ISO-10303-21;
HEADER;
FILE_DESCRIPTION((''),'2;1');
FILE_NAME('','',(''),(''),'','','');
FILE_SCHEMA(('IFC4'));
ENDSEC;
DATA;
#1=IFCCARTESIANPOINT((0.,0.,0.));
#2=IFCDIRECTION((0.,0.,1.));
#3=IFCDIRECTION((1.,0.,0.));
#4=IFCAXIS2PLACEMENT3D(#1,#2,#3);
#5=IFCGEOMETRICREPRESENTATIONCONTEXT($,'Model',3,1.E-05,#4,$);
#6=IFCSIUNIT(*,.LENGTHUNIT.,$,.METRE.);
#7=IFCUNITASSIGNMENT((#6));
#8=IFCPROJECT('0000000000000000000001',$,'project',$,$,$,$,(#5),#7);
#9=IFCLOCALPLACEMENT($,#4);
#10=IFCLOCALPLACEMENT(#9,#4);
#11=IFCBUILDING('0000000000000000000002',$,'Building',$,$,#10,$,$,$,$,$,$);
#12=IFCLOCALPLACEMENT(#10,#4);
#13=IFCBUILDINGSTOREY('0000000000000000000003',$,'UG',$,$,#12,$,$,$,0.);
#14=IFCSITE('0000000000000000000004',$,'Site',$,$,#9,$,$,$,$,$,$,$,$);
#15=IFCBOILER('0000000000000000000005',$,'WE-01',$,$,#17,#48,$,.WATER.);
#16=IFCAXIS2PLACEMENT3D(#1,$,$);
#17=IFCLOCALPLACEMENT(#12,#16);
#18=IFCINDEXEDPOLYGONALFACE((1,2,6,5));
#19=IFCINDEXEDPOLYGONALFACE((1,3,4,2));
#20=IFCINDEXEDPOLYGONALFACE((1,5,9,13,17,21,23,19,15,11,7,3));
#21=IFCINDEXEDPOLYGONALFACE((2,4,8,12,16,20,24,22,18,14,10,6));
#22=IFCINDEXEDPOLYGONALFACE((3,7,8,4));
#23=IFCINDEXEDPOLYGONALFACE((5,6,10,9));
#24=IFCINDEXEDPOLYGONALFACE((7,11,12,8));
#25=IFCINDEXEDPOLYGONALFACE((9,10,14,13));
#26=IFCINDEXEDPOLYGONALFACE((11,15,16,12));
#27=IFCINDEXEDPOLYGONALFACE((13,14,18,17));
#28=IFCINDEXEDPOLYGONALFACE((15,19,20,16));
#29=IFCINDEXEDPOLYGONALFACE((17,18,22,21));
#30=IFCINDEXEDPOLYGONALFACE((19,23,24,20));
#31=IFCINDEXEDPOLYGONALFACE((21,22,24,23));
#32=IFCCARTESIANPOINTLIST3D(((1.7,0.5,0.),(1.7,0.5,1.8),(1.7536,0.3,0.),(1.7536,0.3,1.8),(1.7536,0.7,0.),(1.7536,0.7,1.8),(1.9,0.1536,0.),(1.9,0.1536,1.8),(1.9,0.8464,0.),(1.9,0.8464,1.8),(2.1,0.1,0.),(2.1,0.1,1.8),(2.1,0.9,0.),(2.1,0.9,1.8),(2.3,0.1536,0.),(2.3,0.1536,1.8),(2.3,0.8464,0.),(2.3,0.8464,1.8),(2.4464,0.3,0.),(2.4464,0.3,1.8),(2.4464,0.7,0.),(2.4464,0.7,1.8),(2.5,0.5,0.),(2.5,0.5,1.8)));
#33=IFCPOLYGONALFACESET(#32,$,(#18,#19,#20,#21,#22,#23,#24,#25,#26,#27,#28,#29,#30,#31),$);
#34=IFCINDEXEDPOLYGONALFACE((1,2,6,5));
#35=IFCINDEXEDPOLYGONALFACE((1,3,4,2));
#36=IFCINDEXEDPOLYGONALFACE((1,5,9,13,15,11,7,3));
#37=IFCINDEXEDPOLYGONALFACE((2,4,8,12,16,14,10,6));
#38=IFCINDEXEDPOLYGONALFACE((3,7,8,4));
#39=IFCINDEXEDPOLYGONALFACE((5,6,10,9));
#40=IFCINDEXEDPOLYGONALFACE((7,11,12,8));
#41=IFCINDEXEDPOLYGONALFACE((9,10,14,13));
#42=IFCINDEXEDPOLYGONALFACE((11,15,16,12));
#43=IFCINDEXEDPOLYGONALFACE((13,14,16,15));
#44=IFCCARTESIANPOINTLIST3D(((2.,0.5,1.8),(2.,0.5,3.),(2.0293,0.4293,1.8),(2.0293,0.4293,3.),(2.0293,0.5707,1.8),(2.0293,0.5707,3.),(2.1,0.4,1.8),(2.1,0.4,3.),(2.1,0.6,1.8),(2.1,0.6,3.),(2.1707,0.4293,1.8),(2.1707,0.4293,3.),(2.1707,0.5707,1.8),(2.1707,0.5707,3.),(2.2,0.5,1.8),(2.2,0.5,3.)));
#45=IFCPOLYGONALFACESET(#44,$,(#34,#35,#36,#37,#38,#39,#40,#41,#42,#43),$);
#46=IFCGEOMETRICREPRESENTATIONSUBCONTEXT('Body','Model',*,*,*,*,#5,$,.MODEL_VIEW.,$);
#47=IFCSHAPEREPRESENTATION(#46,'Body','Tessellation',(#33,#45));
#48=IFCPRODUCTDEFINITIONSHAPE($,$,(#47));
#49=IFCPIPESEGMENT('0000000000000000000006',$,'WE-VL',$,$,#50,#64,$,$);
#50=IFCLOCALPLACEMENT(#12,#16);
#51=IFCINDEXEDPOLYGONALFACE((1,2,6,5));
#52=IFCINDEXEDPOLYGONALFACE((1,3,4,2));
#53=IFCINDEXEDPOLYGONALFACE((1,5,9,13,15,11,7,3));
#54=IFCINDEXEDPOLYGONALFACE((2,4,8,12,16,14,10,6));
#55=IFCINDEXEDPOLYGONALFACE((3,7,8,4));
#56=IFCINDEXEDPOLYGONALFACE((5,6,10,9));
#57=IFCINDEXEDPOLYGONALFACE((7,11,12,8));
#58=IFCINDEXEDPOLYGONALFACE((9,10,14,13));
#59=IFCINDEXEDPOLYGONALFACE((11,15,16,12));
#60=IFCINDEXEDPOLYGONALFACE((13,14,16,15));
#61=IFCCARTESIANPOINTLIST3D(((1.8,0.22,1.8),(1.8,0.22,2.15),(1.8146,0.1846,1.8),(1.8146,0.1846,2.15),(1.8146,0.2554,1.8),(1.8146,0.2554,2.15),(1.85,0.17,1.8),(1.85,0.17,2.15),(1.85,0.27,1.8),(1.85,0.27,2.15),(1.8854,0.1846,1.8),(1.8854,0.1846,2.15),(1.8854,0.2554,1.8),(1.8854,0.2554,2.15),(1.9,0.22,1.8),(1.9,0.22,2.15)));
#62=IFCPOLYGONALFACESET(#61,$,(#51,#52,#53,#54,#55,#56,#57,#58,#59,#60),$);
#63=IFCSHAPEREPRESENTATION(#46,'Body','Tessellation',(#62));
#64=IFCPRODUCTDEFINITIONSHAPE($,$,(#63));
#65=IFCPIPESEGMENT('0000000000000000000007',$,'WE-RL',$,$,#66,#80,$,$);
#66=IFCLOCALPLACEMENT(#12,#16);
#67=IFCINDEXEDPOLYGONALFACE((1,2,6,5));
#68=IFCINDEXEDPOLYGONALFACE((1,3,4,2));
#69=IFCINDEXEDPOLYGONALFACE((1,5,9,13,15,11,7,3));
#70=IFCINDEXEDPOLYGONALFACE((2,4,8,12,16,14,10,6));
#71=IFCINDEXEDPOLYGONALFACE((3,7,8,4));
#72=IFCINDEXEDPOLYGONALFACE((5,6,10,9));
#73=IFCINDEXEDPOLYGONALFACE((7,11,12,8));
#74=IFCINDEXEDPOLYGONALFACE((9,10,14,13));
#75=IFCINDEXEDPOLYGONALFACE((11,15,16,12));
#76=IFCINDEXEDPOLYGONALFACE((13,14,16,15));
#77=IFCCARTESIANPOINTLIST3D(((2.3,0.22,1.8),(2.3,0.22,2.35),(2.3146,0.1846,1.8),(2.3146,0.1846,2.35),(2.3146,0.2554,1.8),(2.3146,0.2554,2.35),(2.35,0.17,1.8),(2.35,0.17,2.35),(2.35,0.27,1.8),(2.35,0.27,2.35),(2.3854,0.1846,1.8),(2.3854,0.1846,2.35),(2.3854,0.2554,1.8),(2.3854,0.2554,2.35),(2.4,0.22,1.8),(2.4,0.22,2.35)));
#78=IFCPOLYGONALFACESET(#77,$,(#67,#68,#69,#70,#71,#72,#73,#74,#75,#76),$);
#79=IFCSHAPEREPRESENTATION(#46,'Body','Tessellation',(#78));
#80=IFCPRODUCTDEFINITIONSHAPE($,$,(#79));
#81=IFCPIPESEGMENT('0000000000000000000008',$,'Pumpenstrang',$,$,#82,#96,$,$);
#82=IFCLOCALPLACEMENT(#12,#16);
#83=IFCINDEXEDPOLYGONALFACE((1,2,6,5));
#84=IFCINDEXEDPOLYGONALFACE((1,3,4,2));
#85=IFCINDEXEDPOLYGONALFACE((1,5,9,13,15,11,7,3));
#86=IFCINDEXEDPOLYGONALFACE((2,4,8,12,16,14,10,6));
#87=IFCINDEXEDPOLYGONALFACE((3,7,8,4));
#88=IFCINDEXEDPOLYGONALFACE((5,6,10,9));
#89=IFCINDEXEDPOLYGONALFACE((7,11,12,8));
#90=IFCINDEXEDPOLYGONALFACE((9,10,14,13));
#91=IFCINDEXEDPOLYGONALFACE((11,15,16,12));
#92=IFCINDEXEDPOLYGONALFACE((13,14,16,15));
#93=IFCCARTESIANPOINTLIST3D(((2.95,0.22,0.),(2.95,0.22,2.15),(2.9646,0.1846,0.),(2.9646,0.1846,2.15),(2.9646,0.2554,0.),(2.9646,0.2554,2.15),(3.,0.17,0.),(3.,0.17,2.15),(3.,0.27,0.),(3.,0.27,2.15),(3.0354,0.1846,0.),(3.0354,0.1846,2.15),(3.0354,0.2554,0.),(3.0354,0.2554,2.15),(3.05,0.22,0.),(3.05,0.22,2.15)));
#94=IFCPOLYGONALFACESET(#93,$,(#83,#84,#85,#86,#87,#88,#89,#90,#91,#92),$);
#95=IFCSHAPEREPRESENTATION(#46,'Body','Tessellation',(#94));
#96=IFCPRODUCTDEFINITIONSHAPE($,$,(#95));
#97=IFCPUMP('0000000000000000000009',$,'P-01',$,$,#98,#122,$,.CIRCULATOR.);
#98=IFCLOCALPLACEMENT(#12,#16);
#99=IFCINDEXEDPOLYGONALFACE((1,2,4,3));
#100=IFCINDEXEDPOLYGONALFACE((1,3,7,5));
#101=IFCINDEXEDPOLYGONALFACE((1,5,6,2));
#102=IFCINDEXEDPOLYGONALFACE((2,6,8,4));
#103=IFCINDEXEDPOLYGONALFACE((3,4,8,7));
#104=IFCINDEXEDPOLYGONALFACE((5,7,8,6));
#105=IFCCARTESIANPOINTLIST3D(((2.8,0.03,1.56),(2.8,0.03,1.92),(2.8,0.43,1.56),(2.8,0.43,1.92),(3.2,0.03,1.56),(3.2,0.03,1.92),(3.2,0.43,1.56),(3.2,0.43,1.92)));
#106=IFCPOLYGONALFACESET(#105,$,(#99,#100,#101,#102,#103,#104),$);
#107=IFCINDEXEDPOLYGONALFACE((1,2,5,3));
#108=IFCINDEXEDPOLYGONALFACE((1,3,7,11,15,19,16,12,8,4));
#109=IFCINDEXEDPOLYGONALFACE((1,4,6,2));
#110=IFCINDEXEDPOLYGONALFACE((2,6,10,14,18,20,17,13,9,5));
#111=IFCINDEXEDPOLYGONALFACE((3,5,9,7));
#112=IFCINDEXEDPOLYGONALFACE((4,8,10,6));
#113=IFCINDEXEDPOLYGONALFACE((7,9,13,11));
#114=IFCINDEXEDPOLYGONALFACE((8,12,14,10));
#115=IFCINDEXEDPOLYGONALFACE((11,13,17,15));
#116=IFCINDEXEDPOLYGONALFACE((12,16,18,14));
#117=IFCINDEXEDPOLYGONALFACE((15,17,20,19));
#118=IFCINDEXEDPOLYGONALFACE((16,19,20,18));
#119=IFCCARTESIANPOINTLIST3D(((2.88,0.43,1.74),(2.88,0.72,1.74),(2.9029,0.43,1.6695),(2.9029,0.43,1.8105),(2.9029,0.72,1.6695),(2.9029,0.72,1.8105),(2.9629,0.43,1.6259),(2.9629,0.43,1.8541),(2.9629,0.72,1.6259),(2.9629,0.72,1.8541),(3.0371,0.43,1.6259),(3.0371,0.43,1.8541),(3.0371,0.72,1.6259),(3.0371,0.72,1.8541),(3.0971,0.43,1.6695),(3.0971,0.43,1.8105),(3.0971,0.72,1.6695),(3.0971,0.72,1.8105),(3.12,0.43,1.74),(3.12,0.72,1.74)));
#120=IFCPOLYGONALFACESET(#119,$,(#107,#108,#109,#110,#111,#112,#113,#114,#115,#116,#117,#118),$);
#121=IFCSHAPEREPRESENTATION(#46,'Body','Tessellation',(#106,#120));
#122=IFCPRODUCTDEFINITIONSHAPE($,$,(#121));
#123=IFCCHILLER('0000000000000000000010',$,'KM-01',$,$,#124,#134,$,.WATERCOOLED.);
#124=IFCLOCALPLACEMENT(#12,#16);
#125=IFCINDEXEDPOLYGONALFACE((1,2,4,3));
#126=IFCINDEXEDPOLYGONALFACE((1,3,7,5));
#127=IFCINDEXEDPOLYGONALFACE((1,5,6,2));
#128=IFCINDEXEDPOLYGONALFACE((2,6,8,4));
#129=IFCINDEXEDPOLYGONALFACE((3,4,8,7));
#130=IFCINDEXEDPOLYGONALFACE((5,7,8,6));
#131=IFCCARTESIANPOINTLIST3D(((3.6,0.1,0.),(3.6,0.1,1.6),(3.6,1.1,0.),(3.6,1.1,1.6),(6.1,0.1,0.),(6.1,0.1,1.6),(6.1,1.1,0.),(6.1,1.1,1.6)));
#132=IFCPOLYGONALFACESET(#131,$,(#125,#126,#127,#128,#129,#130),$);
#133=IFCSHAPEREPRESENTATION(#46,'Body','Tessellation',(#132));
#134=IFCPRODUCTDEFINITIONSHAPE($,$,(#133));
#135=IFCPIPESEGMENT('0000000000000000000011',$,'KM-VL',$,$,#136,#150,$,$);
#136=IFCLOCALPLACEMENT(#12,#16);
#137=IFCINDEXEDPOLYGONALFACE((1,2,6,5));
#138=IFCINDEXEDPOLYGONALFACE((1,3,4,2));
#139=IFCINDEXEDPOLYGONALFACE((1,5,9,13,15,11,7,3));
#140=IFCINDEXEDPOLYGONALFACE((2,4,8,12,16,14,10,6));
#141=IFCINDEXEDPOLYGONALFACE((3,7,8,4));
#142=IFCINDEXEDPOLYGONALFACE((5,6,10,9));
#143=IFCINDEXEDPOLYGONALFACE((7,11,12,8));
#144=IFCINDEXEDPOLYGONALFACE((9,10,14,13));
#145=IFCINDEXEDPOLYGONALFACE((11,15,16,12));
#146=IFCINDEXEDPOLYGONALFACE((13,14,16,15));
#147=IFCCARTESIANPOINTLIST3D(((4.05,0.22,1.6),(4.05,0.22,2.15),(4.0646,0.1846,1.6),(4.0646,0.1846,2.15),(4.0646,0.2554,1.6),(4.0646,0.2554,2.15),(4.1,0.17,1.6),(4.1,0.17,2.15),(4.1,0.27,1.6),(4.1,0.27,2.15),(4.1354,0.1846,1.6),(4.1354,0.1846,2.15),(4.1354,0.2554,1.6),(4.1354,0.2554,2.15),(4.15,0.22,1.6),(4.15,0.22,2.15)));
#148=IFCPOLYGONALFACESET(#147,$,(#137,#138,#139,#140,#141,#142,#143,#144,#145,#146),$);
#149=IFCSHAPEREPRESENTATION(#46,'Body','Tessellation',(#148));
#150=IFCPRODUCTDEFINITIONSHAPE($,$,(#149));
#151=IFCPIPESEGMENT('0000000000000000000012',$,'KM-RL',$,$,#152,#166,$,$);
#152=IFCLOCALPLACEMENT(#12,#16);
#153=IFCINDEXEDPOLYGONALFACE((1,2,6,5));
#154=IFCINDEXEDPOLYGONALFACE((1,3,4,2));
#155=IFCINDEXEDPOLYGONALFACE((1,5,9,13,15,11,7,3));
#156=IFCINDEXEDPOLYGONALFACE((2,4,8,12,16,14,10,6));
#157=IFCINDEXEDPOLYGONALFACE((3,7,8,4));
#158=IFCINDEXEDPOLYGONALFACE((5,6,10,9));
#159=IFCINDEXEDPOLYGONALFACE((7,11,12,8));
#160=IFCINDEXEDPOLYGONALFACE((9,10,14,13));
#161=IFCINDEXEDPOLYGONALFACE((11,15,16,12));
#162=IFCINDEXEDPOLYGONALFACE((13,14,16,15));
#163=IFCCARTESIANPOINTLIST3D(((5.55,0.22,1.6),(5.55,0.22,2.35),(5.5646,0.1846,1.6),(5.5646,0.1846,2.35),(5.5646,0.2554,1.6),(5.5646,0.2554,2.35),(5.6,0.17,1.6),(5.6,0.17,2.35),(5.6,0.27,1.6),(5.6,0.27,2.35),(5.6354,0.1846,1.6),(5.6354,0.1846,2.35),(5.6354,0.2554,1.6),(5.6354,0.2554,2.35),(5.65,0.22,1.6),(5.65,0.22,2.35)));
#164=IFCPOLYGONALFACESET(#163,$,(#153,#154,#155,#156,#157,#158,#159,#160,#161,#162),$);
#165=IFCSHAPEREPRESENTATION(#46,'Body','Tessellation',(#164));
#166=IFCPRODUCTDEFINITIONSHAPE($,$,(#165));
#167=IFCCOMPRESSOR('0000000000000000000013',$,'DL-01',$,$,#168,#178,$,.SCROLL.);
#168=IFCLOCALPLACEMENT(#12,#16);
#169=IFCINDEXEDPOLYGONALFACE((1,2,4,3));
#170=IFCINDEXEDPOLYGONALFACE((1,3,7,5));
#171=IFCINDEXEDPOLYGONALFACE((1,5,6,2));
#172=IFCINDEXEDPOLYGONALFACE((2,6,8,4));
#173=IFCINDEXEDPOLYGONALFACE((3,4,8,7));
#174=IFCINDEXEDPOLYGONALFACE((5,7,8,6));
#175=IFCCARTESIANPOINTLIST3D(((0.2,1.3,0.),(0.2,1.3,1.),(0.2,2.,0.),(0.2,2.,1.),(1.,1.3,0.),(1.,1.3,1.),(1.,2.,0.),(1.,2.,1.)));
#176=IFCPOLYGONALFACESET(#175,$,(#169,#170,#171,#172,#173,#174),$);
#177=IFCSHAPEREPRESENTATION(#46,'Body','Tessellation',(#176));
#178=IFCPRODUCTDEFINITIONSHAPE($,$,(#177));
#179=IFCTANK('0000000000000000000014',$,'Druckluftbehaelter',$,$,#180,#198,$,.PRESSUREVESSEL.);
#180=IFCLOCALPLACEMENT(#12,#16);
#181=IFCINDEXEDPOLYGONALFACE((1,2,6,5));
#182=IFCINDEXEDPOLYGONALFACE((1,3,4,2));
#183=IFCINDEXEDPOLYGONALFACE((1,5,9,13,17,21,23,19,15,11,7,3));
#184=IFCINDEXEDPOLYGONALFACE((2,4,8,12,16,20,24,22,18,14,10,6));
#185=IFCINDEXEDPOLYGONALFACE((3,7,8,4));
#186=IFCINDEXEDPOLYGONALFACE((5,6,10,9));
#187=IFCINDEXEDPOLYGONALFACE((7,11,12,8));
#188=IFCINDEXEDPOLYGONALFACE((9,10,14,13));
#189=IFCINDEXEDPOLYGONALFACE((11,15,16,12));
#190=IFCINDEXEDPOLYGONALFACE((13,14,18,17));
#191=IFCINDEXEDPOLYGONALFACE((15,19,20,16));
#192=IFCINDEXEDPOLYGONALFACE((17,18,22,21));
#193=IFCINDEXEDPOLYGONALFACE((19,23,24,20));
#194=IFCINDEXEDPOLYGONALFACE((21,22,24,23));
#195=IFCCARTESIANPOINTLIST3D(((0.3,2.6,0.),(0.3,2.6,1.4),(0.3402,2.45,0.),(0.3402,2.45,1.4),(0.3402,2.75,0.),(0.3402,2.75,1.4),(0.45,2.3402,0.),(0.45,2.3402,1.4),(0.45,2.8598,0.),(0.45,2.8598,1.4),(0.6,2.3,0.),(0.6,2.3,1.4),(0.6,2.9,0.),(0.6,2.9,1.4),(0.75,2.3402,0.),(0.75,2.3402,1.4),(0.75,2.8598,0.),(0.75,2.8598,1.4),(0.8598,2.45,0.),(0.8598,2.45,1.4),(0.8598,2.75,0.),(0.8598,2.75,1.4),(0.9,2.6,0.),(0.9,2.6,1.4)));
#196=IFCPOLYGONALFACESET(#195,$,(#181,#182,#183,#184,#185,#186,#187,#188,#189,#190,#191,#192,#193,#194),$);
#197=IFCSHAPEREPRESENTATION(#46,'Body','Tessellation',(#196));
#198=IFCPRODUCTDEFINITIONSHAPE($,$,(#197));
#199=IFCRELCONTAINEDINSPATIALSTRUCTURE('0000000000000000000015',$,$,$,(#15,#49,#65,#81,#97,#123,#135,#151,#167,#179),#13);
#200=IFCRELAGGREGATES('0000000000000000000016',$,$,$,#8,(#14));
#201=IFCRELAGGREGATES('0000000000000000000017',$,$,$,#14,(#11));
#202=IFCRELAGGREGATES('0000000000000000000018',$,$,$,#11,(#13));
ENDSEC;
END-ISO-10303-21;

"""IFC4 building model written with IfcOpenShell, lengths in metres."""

from ifc_helpers import new_model, si_unit, frame, origin_with_axes, place, context, subcontext, project, spatial, polyline, outline, extrude, element, save


model = new_model("IFC4")

# Units and contexts
model_context = context("Model", 3, precision=1e-05, world=origin_with_axes())
body_context = subcontext(model_context, "Body", "Model", "MODEL_VIEW")
ifc_project = project(units=[si_unit("LENGTHUNIT", "METRE")], contexts=[model_context])

# Site, building, storey
site_placement = place(None, origin_with_axes())
site = spatial("IfcSite", under=ifc_project, at=site_placement, Name="Site")
building_placement = place(site_placement, origin_with_axes())
building = spatial("IfcBuilding", under=site, at=building_placement, Name="Building")
storey_placement = place(building_placement, origin_with_axes())
storey = spatial("IfcBuildingStorey", under=building, at=storey_placement, Name="UG", Elevation=0.0)

# Boiler
boiler_placement = place(storey_placement, origin_with_axes())
element("IfcBoiler", 1, at=boiler_placement, inside=storey, Name="WE-01", PredefinedType="WATER", context=body_context, shape_type="SweptSolid", body=[
    extrude(outline(polyline([(0.4, 0.0, 0.0), (0.3464, 0.2, 0.0), (0.2, 0.3464, 0.0), (0.0, 0.4, 0.0), (-0.2, 0.3464, 0.0), (-0.3464, 0.2, 0.0), (-0.4, 0.0, 0.0), (-0.3464, -0.2, 0.0), (-0.2, -0.3464, 0.0), (0.0, -0.4, 0.0), (0.2, -0.3464, 0.0), (0.3464, -0.2, 0.0), (0.4, 0.0, 0.0)])), frame((2.1, 0.5, 0.0), z_axis=(0.0, 0.0, 1.0), x_axis=(1.0, 0.0, 0.0)), (0.0, 0.0, 1.0), 1.8),
    extrude(outline(polyline([(0.1, 0.0, 0.0), (0.0707, 0.0707, 0.0), (0.0, 0.1, 0.0), (-0.0707, 0.0707, 0.0), (-0.1, 0.0, 0.0), (-0.0707, -0.0707, 0.0), (0.0, -0.1, 0.0), (0.0707, -0.0707, 0.0), (0.1, 0.0, 0.0)])), frame((2.1, 0.5, 1.8), z_axis=(0.0, 0.0, 1.0), x_axis=(1.0, 0.0, 0.0)), (0.0, 0.0, 1.0), 1.2),
])

# Pipe segments
pipe_segment_1_placement = place(storey_placement, origin_with_axes())
element("IfcPipeSegment", 2, at=pipe_segment_1_placement, inside=storey, Name="WE-VL", context=body_context, shape_type="SweptSolid", body=[
    extrude(outline(polyline([(0.05, 0.0, 0.0), (0.0354, 0.0354, 0.0), (0.0, 0.05, 0.0), (-0.0354, 0.0354, 0.0), (-0.05, 0.0, 0.0), (-0.0354, -0.0354, 0.0), (0.0, -0.05, 0.0), (0.0354, -0.0354, 0.0), (0.05, 0.0, 0.0)])), frame((1.85, 0.22, 1.8), z_axis=(0.0, 0.0, 1.0), x_axis=(1.0, 0.0, 0.0)), (0.0, 0.0, 1.0), 0.35),
])
pipe_segment_2_placement = place(storey_placement, origin_with_axes())
element("IfcPipeSegment", 3, at=pipe_segment_2_placement, inside=storey, Name="WE-RL", context=body_context, shape_type="SweptSolid", body=[
    extrude(outline(polyline([(0.05, 0.0, 0.0), (0.0354, 0.0354, 0.0), (0.0, 0.05, 0.0), (-0.0354, 0.0354, 0.0), (-0.05, 0.0, 0.0), (-0.0354, -0.0354, 0.0), (0.0, -0.05, 0.0), (0.0354, -0.0354, 0.0), (0.05, 0.0, 0.0)])), frame((2.35, 0.22, 1.8), z_axis=(0.0, 0.0, 1.0), x_axis=(1.0, 0.0, 0.0)), (0.0, 0.0, 1.0), 0.55),
])
pipe_segment_3_placement = place(storey_placement, origin_with_axes())
element("IfcPipeSegment", 4, at=pipe_segment_3_placement, inside=storey, Name="Pumpenstrang", context=body_context, shape_type="SweptSolid", body=[
    extrude(outline(polyline([(0.05, 0.0, 0.0), (0.0354, 0.0354, 0.0), (0.0, 0.05, 0.0), (-0.0354, 0.0354, 0.0), (-0.05, 0.0, 0.0), (-0.0354, -0.0354, 0.0), (0.0, -0.05, 0.0), (0.0354, -0.0354, 0.0), (0.05, 0.0, 0.0)])), frame((3.0, 0.22, 0.0), z_axis=(0.0, 0.0, 1.0), x_axis=(1.0, 0.0, 0.0)), (0.0, 0.0, 1.0), 2.15),
])

# Pump
pump_placement = place(storey_placement, origin_with_axes())
element("IfcPump", 5, at=pump_placement, inside=storey, Name="P-01", PredefinedType="CIRCULATOR", context=body_context, shape_type="SweptSolid", body=[
    extrude(outline(polyline([(2.8, 0.03, 0.0), (3.2, 0.03, 0.0), (3.2, 0.43, 0.0), (2.8, 0.43, 0.0), (2.8, 0.03, 0.0)])), frame((0.0, 0.0, 1.56), z_axis=(0.0, 0.0, 1.0), x_axis=(1.0, 0.0, 0.0)), (0.0, 0.0, 1.0), 0.36),
    extrude(outline(polyline([(0.12, 0.0, 0.0), (0.0971, 0.0705, 0.0), (0.0371, 0.1141, 0.0), (-0.0371, 0.1141, 0.0), (-0.0971, 0.0705, 0.0), (-0.12, 0.0, 0.0), (-0.0971, -0.0705, 0.0), (-0.0371, -0.1141, 0.0), (0.0371, -0.1141, 0.0), (0.0971, -0.0705, 0.0), (0.12, 0.0, 0.0)])), frame((3.0, 0.43, 1.74), z_axis=(0.0, 1.0, 0.0), x_axis=(-1.0, 0.0, 0.0)), (0.0, 0.0, 1.0), 0.29),
])

# Chiller
chiller_placement = place(storey_placement, origin_with_axes())
element("IfcChiller", 6, at=chiller_placement, inside=storey, Name="KM-01", PredefinedType="WATERCOOLED", context=body_context, shape_type="SweptSolid", body=[
    extrude(outline(polyline([(3.6, 0.1, 0.0), (6.1, 0.1, 0.0), (6.1, 1.1, 0.0), (3.6, 1.1, 0.0), (3.6, 0.1, 0.0)])), origin_with_axes(), (0.0, 0.0, 1.0), 1.6),
])

# Pipe segments
pipe_segment_4_placement = place(storey_placement, origin_with_axes())
element("IfcPipeSegment", 7, at=pipe_segment_4_placement, inside=storey, Name="KM-VL", context=body_context, shape_type="SweptSolid", body=[
    extrude(outline(polyline([(0.05, 0.0, 0.0), (0.0354, 0.0354, 0.0), (0.0, 0.05, 0.0), (-0.0354, 0.0354, 0.0), (-0.05, 0.0, 0.0), (-0.0354, -0.0354, 0.0), (0.0, -0.05, 0.0), (0.0354, -0.0354, 0.0), (0.05, 0.0, 0.0)])), frame((4.1, 0.22, 1.6), z_axis=(0.0, 0.0, 1.0), x_axis=(1.0, 0.0, 0.0)), (0.0, 0.0, 1.0), 0.55),
])
pipe_segment_5_placement = place(storey_placement, origin_with_axes())
element("IfcPipeSegment", 8, at=pipe_segment_5_placement, inside=storey, Name="KM-RL", context=body_context, shape_type="SweptSolid", body=[
    extrude(outline(polyline([(0.05, 0.0, 0.0), (0.0354, 0.0354, 0.0), (0.0, 0.05, 0.0), (-0.0354, 0.0354, 0.0), (-0.05, 0.0, 0.0), (-0.0354, -0.0354, 0.0), (0.0, -0.05, 0.0), (0.0354, -0.0354, 0.0), (0.05, 0.0, 0.0)])), frame((5.6, 0.22, 1.6), z_axis=(0.0, 0.0, 1.0), x_axis=(1.0, 0.0, 0.0)), (0.0, 0.0, 1.0), 0.75),
])

# Compressor
compressor_placement = place(storey_placement, origin_with_axes())
element("IfcCompressor", 9, at=compressor_placement, inside=storey, Name="DL-01", PredefinedType="SCROLL", context=body_context, shape_type="SweptSolid", body=[
    extrude(outline(polyline([(0.2, 1.3, 0.0), (1.0, 1.3, 0.0), (1.0, 2.0, 0.0), (0.2, 2.0, 0.0), (0.2, 1.3, 0.0)])), origin_with_axes(), (0.0, 0.0, 1.0), 1.0),
])

# Tank
tank_1_placement = place(storey_placement, origin_with_axes())
element("IfcTank", 10, at=tank_1_placement, inside=storey, Name="Druckluftbehaelter", PredefinedType="PRESSUREVESSEL", context=body_context, shape_type="SweptSolid", body=[
    extrude(outline(polyline([(0.3, 0.0, 0.0), (0.2598, 0.15, 0.0), (0.15, 0.2598, 0.0), (0.0, 0.3, 0.0), (-0.15, 0.2598, 0.0), (-0.2598, 0.15, 0.0), (-0.3, 0.0, 0.0), (-0.2598, -0.15, 0.0), (-0.15, -0.2598, 0.0), (0.0, -0.3, 0.0), (0.15, -0.2598, 0.0), (0.2598, -0.15, 0.0), (0.3, 0.0, 0.0)])), frame((0.6, 2.6, 0.0), z_axis=(0.0, 0.0, 1.0), x_axis=(1.0, 0.0, 0.0)), (0.0, 0.0, 1.0), 1.4),
])

save(model, "model.ifc")
